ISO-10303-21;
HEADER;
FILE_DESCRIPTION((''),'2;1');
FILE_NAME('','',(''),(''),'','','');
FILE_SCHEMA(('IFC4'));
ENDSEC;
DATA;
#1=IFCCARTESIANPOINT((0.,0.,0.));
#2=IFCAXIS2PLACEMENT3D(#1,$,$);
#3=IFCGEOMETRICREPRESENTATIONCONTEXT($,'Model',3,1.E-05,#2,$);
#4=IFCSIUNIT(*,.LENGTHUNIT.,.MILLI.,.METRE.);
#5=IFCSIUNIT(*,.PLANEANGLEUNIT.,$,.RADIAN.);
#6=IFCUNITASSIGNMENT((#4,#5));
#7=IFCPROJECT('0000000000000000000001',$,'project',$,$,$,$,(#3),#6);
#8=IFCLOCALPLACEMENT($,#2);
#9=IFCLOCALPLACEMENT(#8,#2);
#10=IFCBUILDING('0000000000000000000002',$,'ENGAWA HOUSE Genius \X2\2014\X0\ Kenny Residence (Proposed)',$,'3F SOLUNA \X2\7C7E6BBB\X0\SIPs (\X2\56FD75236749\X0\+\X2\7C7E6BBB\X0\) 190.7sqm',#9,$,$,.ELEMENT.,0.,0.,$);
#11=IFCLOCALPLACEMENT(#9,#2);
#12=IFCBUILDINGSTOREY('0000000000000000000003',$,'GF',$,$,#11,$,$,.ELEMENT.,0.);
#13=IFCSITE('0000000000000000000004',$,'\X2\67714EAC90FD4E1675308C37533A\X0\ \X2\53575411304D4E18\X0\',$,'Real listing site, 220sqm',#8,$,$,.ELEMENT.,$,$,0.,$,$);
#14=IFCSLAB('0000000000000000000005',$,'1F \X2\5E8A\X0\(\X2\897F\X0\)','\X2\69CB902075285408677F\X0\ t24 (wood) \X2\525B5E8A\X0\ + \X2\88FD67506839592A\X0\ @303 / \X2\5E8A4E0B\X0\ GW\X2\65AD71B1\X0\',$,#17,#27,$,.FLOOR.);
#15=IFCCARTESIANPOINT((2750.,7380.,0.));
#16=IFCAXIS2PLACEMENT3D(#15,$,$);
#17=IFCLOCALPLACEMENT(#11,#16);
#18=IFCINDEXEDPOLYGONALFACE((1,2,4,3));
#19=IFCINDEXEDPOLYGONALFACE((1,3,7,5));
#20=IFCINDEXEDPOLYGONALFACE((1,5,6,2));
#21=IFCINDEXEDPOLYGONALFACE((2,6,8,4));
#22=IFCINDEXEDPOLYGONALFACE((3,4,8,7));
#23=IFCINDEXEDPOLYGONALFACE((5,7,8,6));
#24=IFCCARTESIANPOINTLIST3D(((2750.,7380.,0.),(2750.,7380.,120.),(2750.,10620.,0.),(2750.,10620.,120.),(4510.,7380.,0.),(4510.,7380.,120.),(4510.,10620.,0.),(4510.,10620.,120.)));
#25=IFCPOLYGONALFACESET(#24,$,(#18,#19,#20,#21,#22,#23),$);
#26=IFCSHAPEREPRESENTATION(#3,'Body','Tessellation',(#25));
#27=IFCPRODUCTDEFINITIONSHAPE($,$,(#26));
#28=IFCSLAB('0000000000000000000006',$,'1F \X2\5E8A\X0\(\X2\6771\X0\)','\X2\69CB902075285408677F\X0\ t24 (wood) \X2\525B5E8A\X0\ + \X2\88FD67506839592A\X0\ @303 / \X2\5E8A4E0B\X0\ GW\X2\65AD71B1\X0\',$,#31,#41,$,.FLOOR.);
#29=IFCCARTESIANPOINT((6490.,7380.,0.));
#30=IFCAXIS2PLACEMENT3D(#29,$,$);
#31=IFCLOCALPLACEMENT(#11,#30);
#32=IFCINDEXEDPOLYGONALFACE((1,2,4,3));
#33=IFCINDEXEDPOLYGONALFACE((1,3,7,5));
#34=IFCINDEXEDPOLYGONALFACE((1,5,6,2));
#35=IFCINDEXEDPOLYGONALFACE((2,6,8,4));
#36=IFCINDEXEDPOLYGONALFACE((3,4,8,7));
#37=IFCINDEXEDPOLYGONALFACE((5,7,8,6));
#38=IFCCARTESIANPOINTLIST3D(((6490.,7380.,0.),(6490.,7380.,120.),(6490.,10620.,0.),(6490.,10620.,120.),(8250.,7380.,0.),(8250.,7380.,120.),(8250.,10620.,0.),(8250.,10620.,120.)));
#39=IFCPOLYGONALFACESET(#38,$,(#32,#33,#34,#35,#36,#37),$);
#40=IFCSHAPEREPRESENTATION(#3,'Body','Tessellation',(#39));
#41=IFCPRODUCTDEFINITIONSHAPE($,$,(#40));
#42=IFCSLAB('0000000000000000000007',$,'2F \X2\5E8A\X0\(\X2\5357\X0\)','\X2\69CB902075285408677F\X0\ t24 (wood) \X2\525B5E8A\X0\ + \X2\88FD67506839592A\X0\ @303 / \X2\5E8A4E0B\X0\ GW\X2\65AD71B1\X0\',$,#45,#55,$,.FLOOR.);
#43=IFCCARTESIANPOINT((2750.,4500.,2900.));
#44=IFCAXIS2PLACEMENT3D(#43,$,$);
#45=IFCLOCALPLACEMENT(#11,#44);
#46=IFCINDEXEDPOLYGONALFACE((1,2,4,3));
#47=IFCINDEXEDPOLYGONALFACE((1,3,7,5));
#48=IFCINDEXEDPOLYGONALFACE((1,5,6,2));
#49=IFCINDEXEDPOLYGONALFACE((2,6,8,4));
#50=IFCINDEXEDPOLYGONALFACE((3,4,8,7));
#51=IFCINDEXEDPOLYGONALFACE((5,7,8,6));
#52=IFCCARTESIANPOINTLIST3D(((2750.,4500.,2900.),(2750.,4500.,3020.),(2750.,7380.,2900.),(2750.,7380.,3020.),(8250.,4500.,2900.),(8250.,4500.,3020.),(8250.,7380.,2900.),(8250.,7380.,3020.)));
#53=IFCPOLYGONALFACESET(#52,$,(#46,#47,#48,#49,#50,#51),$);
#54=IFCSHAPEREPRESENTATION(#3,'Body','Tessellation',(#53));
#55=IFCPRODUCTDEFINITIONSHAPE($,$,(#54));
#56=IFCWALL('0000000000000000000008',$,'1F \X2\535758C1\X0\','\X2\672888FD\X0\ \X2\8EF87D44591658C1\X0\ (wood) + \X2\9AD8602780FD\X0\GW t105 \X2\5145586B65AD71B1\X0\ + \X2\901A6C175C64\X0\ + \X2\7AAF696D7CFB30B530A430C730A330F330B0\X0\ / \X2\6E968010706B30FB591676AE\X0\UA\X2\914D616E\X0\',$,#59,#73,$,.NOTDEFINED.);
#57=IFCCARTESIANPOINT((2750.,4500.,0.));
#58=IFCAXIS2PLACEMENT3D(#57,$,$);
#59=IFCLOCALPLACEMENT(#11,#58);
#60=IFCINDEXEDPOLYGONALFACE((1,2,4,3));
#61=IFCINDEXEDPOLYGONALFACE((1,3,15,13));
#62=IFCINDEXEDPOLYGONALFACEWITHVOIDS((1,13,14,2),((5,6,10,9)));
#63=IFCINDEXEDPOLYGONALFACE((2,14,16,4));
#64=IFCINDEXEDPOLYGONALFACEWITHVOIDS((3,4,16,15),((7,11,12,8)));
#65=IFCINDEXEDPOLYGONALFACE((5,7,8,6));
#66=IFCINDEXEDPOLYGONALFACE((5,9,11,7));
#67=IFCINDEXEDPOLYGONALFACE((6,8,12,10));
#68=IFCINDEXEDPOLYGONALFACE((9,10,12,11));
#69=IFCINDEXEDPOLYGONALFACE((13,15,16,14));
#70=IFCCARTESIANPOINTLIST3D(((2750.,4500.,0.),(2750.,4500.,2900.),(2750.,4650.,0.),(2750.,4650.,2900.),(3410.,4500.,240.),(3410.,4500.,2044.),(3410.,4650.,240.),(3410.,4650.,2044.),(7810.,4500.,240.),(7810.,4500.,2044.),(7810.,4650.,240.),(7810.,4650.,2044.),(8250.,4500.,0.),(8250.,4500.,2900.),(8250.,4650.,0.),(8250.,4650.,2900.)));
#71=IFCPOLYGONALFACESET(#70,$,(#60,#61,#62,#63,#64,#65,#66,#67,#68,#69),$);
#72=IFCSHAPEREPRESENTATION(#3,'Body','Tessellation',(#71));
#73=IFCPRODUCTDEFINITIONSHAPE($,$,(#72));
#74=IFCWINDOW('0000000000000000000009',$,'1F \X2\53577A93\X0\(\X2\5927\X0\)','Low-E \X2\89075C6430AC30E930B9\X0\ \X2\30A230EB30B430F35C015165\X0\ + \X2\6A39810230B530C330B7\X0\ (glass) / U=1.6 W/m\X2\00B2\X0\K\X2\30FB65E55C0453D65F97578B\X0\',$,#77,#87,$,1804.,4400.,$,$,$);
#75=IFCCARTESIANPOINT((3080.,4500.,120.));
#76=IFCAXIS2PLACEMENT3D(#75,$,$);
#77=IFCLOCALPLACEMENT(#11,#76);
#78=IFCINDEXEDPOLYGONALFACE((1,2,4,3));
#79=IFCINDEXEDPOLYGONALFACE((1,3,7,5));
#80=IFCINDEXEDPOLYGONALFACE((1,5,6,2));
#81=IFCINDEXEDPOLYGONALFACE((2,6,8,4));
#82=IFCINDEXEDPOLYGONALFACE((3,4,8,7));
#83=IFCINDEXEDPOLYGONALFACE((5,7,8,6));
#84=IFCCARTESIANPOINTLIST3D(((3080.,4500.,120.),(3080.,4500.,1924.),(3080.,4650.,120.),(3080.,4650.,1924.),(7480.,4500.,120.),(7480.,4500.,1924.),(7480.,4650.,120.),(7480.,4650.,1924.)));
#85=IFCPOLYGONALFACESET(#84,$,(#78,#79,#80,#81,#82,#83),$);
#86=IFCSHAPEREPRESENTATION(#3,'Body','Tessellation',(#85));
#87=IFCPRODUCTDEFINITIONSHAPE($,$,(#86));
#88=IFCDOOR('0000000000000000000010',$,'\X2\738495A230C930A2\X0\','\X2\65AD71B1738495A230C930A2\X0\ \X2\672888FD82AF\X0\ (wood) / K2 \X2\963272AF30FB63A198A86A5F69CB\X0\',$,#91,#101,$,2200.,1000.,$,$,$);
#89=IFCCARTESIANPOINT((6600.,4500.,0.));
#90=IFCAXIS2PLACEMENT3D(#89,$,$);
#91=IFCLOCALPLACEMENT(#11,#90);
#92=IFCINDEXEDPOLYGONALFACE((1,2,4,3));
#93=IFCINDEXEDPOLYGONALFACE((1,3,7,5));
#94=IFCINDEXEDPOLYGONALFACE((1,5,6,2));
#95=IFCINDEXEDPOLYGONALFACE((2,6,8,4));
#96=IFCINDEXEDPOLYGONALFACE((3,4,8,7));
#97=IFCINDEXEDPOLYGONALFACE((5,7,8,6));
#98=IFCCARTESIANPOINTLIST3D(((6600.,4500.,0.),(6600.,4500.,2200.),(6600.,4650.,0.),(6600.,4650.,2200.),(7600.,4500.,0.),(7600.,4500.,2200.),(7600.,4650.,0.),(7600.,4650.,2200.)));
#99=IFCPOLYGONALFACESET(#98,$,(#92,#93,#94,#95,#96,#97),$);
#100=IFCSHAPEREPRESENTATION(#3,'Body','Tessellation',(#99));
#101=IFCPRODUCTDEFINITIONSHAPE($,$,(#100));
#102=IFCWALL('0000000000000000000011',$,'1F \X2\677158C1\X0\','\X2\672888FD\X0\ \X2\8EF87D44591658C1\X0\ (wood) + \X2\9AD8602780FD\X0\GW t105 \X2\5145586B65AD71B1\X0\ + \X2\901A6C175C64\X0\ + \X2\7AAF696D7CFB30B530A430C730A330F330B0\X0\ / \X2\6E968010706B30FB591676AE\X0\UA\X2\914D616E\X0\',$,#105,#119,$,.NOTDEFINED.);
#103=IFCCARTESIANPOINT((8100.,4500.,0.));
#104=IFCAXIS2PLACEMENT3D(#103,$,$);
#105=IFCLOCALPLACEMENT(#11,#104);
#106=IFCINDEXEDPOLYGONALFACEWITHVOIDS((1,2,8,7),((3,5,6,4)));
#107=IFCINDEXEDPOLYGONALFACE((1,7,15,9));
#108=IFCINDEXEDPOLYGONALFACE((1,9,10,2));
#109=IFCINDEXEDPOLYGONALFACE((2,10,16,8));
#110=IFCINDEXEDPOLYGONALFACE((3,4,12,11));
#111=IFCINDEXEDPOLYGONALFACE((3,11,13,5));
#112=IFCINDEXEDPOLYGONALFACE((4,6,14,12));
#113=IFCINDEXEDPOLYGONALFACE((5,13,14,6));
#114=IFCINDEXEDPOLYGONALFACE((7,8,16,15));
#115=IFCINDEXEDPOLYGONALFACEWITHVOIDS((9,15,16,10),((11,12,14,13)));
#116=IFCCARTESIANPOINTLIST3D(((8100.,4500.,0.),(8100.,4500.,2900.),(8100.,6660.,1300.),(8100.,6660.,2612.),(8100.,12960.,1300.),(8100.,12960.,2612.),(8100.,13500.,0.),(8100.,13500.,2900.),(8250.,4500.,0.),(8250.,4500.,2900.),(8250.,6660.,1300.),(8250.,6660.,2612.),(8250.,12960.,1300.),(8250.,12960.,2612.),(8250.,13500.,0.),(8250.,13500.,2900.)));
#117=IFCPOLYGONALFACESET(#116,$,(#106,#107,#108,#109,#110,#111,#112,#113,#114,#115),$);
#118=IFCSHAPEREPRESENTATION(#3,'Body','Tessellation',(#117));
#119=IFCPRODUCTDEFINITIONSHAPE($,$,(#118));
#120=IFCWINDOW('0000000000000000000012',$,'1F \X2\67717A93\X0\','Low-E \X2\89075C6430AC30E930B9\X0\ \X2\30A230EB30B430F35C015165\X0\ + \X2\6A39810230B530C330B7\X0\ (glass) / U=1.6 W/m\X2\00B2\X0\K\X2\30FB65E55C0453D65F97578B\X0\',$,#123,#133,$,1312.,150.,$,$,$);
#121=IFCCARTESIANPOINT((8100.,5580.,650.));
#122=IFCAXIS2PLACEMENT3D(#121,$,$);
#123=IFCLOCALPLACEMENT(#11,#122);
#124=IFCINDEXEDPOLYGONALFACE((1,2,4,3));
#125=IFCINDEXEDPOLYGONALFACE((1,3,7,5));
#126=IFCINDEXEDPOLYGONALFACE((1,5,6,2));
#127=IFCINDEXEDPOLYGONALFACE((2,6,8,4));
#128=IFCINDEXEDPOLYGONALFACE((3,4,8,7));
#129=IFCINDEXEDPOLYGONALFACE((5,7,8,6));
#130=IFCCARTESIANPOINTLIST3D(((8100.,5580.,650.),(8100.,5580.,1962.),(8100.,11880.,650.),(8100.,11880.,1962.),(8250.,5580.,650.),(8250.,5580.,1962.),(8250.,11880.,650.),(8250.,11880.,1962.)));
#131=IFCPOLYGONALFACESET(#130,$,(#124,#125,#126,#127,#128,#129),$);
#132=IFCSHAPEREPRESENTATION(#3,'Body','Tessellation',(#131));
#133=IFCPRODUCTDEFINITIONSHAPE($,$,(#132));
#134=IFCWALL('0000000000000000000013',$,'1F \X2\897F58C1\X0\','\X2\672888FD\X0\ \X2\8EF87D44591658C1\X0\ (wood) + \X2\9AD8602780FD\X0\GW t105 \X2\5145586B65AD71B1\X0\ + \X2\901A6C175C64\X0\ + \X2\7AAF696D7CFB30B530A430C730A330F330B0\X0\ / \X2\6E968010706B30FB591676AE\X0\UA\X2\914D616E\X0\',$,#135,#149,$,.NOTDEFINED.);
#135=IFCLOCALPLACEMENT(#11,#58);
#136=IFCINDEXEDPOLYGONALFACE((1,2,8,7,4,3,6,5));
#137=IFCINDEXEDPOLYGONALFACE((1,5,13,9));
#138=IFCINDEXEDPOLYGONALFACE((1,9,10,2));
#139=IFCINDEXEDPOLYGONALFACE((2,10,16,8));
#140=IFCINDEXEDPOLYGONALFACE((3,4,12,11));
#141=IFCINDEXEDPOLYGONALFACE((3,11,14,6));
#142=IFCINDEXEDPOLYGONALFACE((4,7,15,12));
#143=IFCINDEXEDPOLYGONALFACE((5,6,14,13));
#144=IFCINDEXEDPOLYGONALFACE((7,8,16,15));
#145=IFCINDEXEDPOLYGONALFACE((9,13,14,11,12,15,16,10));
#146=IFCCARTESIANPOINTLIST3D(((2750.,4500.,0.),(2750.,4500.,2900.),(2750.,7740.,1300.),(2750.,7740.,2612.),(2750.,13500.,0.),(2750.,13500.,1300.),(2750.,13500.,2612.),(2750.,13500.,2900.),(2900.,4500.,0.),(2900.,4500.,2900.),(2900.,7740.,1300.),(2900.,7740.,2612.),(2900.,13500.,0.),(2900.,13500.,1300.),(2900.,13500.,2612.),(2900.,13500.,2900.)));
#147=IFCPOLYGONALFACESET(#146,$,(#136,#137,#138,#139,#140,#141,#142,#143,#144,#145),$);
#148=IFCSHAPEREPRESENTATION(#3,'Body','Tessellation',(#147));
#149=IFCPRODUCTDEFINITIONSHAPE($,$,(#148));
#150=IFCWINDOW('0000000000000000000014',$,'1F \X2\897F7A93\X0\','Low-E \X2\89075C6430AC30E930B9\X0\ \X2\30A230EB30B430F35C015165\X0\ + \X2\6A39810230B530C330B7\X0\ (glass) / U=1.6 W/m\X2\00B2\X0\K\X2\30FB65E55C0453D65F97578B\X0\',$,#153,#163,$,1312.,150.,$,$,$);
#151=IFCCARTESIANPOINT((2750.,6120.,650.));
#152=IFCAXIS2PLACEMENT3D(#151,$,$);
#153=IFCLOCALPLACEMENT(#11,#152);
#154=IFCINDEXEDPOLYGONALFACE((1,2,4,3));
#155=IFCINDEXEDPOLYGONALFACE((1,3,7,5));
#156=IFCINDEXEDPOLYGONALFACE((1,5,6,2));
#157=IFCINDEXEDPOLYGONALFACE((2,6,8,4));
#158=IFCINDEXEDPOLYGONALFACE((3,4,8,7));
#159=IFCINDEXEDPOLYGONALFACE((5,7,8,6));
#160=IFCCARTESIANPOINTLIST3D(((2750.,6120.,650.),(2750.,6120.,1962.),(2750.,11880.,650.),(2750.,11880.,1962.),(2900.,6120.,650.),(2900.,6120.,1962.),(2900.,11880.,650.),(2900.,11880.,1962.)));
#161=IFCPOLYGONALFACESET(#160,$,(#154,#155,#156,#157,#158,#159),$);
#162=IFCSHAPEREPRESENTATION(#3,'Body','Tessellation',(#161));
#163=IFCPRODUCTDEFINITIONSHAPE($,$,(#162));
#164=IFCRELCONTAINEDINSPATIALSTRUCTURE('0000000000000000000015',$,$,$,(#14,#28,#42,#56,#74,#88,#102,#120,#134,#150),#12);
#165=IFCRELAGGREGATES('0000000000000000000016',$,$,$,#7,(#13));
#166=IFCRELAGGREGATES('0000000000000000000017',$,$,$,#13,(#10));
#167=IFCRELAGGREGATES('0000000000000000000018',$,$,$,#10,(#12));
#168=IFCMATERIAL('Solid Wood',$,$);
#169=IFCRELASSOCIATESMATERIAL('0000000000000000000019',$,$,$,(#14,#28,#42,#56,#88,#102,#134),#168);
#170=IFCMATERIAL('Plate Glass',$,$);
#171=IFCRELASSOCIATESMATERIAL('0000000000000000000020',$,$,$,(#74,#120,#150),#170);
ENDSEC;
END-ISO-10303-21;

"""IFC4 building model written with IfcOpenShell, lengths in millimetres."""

from ifc_helpers import new_model, si_unit, frame, frame_2d, origin, place, context, project, spatial, rectangle, extrude, material, element, fill, save


model = new_model("IFC4")

# Units and contexts
model_context = context("Model", 3, precision=1e-05, world=origin())
ifc_project = project(units=[si_unit("LENGTHUNIT", "METRE", prefix="MILLI"), si_unit("PLANEANGLEUNIT", "RADIAN")], contexts=[model_context])

# Site, building, storey
site_placement = place(None, origin())
site = spatial("IfcSite", under=ifc_project, at=site_placement, Name="東京都世田谷区 南向き丘", ObjectType="Real listing site, 220sqm", CompositionType="ELEMENT", RefElevation=0.0)
building_placement = place(site_placement, origin())
building = spatial("IfcBuilding", under=site, at=building_placement, Name="ENGAWA HOUSE Genius — Kenny Residence (Proposed)", ObjectType="3F SOLUNA 籾殻SIPs (国産杉+籾殻) 190.7sqm", CompositionType="ELEMENT", ElevationOfRefHeight=0.0, ElevationOfTerrain=0.0)
storey_placement = place(building_placement, origin())
storey = spatial("IfcBuildingStorey", under=building, at=storey_placement, Name="GF", CompositionType="ELEMENT", Elevation=0.0)

# Slabs
ifc_material_1 = material(Name="Solid Wood")
slab_1_placement = place(storey_placement, frame((2750.0, 7380.0, 0.0)))
element("IfcSlab", 1, at=slab_1_placement, inside=storey, material=ifc_material_1, Name="1F 床(西)", Description="構造用合板 t24 (wood) 剛床 + 製材根太 @303 / 床下 GW断熱", PredefinedType="FLOOR", context=model_context, shape_type="SweptSolid", body=[
    extrude(rectangle(XDim=1760.0, YDim=3240.0, at=frame_2d((880.0, 1620.0))), frame((2750.0, 7380.0, 0.0)), (0.0, 0.0, 1.0), 120.0),
])
slab_2_placement = place(storey_placement, frame((6490.0, 7380.0, 0.0)))
element("IfcSlab", 2, at=slab_2_placement, inside=storey, material=ifc_material_1, Name="1F 床(東)", Description="構造用合板 t24 (wood) 剛床 + 製材根太 @303 / 床下 GW断熱", PredefinedType="FLOOR", context=model_context, shape_type="SweptSolid", body=[
    extrude(rectangle(XDim=1760.0, YDim=3240.0, at=frame_2d((880.0, 1620.0))), frame((6490.0, 7380.0, 0.0)), (0.0, 0.0, 1.0), 120.0),
])
slab_3_placement = place(storey_placement, frame((2750.0, 4500.0, 2900.0)))
element("IfcSlab", 3, at=slab_3_placement, inside=storey, material=ifc_material_1, Name="2F 床(南)", Description="構造用合板 t24 (wood) 剛床 + 製材根太 @303 / 床下 GW断熱", PredefinedType="FLOOR", context=model_context, shape_type="SweptSolid", body=[
    extrude(rectangle(XDim=5500.0, YDim=2880.0, at=frame_2d((2750.0, 1440.0))), frame((2750.0, 4500.0, 2900.0)), (0.0, 0.0, 1.0), 120.0),
])

# Wall, openings, window, door
wall_1_placement = place(storey_placement, frame((2750.0, 4500.0, 0.0)))
wall_1 = element("IfcWall", 4, at=wall_1_placement, inside=storey, material=ifc_material_1, Name="1F 南壁", Description="木製 軸組外壁 (wood) + 高性能GW t105 充填断熱 + 通気層 + 窯業系サイディング / 準耐火・外皮UA配慮", PredefinedType="NOTDEFINED", context=model_context, shape_type="SweptSolid", body=[
    extrude(rectangle(XDim=5500.0, YDim=150.0, at=frame_2d((2750.0, 75.0))), frame((2750.0, 4500.0, 0.0)), (0.0, 0.0, 1.0), 2900.0),
])
opening_1_placement = place(storey_placement, frame((3080.0, 4500.0, 120.0)))
opening_1 = element("IfcOpeningElement", 5, at=opening_1_placement, cuts=wall_1, PredefinedType="NOTDEFINED", context=model_context, shape_type="SweptSolid", body=[
    extrude(rectangle(XDim=4400.0, YDim=150.0, at=frame_2d((2200.0, 75.0))), frame((3080.0, 4500.0, 120.0)), (0.0, 0.0, 1.0), 1804.0),
])
opening_2_placement = place(storey_placement, frame((6600.0, 4500.0, 0.0)))
opening_2 = element("IfcOpeningElement", 6, at=opening_2_placement, cuts=wall_1, PredefinedType="NOTDEFINED", context=model_context, shape_type="SweptSolid", body=[
    extrude(rectangle(XDim=1000.0, YDim=150.0, at=frame_2d((500.0, 75.0))), frame((6600.0, 4500.0, 0.0)), (0.0, 0.0, 1.0), 2200.0),
])
ifc_material_2 = material(Name="Plate Glass")
window_1_placement = place(storey_placement, frame((3080.0, 4500.0, 120.0)))
window_1 = element("IfcWindow", 7, at=window_1_placement, inside=storey, material=ifc_material_2, Name="1F 南窓(大)", Description="Low-E 複層ガラス アルゴン封入 + 樹脂サッシ (glass) / U=1.6 W/m²K・日射取得型", OverallHeight=1804.0, OverallWidth=4400.0, context=model_context, shape_type="SweptSolid", body=[
    extrude(rectangle(XDim=4400.0, YDim=150.0, at=frame_2d((2200.0, 75.0))), frame((3080.0, 4500.0, 120.0)), (0.0, 0.0, 1.0), 1804.0),
])
fill(opening_1, window_1)
door_placement = place(storey_placement, frame((6600.0, 4500.0, 0.0)))
door = element("IfcDoor", 8, at=door_placement, inside=storey, material=ifc_material_1, Name="玄関ドア", Description="断熱玄関ドア 木製芯 (wood) / K2 防犯・採風機構", OverallHeight=2200.0, OverallWidth=1000.0, context=model_context, shape_type="SweptSolid", body=[
    extrude(rectangle(XDim=1000.0, YDim=150.0, at=frame_2d((500.0, 75.0))), frame((6600.0, 4500.0, 0.0)), (0.0, 0.0, 1.0), 2200.0),
])
fill(opening_2, door)

# Walls, openings, windows
wall_2_placement = place(storey_placement, frame((8100.0, 4500.0, 0.0)))
wall_2 = element("IfcWall", 9, at=wall_2_placement, inside=storey, material=ifc_material_1, Name="1F 東壁", Description="木製 軸組外壁 (wood) + 高性能GW t105 充填断熱 + 通気層 + 窯業系サイディング / 準耐火・外皮UA配慮", PredefinedType="NOTDEFINED", context=model_context, shape_type="SweptSolid", body=[
    extrude(rectangle(XDim=150.0, YDim=9000.0, at=frame_2d((75.0, 4500.0))), frame((8100.0, 4500.0, 0.0)), (0.0, 0.0, 1.0), 2900.0),
])
opening_3_placement = place(storey_placement, frame((8100.0, 5580.0, 650.0)))
opening_3 = element("IfcOpeningElement", 10, at=opening_3_placement, cuts=wall_2, PredefinedType="NOTDEFINED", context=model_context, shape_type="SweptSolid", body=[
    extrude(rectangle(XDim=150.0, YDim=6300.0, at=frame_2d((75.0, 3150.0))), frame((8100.0, 5580.0, 650.0)), (0.0, 0.0, 1.0), 1312.0),
])
window_2_placement = place(storey_placement, frame((8100.0, 5580.0, 650.0)))
window_2 = element("IfcWindow", 11, at=window_2_placement, inside=storey, material=ifc_material_2, Name="1F 東窓", Description="Low-E 複層ガラス アルゴン封入 + 樹脂サッシ (glass) / U=1.6 W/m²K・日射取得型", OverallHeight=1312.0, OverallWidth=150.0, context=model_context, shape_type="SweptSolid", body=[
    extrude(rectangle(XDim=150.0, YDim=6300.0, at=frame_2d((75.0, 3150.0))), frame((8100.0, 5580.0, 650.0)), (0.0, 0.0, 1.0), 1312.0),
])
fill(opening_3, window_2)
wall_3_placement = place(storey_placement, frame((2750.0, 4500.0, 0.0)))
wall_3 = element("IfcWall", 12, at=wall_3_placement, inside=storey, material=ifc_material_1, Name="1F 西壁", Description="木製 軸組外壁 (wood) + 高性能GW t105 充填断熱 + 通気層 + 窯業系サイディング / 準耐火・外皮UA配慮", PredefinedType="NOTDEFINED", context=model_context, shape_type="SweptSolid", body=[
    extrude(rectangle(XDim=150.0, YDim=9000.0, at=frame_2d((75.0, 4500.0))), frame((2750.0, 4500.0, 0.0)), (0.0, 0.0, 1.0), 2900.0),
])
opening_4_placement = place(storey_placement, frame((2750.0, 6120.0, 650.0)))
opening_4 = element("IfcOpeningElement", 13, at=opening_4_placement, cuts=wall_3, PredefinedType="NOTDEFINED", context=model_context, shape_type="SweptSolid", body=[
    extrude(rectangle(XDim=150.0, YDim=5760.0, at=frame_2d((75.0, 2880.0))), frame((2750.0, 6120.0, 650.0)), (0.0, 0.0, 1.0), 1312.0),
])
window_3_placement = place(storey_placement, frame((2750.0, 6120.0, 650.0)))
window_3 = element("IfcWindow", 14, at=window_3_placement, inside=storey, material=ifc_material_2, Name="1F 西窓", Description="Low-E 複層ガラス アルゴン封入 + 樹脂サッシ (glass) / U=1.6 W/m²K・日射取得型", OverallHeight=1312.0, OverallWidth=150.0, context=model_context, shape_type="SweptSolid", body=[
    extrude(rectangle(XDim=150.0, YDim=5760.0, at=frame_2d((75.0, 2880.0))), frame((2750.0, 6120.0, 650.0)), (0.0, 0.0, 1.0), 1312.0),
])
fill(opening_4, window_3)

save(model, "model.ifc")
